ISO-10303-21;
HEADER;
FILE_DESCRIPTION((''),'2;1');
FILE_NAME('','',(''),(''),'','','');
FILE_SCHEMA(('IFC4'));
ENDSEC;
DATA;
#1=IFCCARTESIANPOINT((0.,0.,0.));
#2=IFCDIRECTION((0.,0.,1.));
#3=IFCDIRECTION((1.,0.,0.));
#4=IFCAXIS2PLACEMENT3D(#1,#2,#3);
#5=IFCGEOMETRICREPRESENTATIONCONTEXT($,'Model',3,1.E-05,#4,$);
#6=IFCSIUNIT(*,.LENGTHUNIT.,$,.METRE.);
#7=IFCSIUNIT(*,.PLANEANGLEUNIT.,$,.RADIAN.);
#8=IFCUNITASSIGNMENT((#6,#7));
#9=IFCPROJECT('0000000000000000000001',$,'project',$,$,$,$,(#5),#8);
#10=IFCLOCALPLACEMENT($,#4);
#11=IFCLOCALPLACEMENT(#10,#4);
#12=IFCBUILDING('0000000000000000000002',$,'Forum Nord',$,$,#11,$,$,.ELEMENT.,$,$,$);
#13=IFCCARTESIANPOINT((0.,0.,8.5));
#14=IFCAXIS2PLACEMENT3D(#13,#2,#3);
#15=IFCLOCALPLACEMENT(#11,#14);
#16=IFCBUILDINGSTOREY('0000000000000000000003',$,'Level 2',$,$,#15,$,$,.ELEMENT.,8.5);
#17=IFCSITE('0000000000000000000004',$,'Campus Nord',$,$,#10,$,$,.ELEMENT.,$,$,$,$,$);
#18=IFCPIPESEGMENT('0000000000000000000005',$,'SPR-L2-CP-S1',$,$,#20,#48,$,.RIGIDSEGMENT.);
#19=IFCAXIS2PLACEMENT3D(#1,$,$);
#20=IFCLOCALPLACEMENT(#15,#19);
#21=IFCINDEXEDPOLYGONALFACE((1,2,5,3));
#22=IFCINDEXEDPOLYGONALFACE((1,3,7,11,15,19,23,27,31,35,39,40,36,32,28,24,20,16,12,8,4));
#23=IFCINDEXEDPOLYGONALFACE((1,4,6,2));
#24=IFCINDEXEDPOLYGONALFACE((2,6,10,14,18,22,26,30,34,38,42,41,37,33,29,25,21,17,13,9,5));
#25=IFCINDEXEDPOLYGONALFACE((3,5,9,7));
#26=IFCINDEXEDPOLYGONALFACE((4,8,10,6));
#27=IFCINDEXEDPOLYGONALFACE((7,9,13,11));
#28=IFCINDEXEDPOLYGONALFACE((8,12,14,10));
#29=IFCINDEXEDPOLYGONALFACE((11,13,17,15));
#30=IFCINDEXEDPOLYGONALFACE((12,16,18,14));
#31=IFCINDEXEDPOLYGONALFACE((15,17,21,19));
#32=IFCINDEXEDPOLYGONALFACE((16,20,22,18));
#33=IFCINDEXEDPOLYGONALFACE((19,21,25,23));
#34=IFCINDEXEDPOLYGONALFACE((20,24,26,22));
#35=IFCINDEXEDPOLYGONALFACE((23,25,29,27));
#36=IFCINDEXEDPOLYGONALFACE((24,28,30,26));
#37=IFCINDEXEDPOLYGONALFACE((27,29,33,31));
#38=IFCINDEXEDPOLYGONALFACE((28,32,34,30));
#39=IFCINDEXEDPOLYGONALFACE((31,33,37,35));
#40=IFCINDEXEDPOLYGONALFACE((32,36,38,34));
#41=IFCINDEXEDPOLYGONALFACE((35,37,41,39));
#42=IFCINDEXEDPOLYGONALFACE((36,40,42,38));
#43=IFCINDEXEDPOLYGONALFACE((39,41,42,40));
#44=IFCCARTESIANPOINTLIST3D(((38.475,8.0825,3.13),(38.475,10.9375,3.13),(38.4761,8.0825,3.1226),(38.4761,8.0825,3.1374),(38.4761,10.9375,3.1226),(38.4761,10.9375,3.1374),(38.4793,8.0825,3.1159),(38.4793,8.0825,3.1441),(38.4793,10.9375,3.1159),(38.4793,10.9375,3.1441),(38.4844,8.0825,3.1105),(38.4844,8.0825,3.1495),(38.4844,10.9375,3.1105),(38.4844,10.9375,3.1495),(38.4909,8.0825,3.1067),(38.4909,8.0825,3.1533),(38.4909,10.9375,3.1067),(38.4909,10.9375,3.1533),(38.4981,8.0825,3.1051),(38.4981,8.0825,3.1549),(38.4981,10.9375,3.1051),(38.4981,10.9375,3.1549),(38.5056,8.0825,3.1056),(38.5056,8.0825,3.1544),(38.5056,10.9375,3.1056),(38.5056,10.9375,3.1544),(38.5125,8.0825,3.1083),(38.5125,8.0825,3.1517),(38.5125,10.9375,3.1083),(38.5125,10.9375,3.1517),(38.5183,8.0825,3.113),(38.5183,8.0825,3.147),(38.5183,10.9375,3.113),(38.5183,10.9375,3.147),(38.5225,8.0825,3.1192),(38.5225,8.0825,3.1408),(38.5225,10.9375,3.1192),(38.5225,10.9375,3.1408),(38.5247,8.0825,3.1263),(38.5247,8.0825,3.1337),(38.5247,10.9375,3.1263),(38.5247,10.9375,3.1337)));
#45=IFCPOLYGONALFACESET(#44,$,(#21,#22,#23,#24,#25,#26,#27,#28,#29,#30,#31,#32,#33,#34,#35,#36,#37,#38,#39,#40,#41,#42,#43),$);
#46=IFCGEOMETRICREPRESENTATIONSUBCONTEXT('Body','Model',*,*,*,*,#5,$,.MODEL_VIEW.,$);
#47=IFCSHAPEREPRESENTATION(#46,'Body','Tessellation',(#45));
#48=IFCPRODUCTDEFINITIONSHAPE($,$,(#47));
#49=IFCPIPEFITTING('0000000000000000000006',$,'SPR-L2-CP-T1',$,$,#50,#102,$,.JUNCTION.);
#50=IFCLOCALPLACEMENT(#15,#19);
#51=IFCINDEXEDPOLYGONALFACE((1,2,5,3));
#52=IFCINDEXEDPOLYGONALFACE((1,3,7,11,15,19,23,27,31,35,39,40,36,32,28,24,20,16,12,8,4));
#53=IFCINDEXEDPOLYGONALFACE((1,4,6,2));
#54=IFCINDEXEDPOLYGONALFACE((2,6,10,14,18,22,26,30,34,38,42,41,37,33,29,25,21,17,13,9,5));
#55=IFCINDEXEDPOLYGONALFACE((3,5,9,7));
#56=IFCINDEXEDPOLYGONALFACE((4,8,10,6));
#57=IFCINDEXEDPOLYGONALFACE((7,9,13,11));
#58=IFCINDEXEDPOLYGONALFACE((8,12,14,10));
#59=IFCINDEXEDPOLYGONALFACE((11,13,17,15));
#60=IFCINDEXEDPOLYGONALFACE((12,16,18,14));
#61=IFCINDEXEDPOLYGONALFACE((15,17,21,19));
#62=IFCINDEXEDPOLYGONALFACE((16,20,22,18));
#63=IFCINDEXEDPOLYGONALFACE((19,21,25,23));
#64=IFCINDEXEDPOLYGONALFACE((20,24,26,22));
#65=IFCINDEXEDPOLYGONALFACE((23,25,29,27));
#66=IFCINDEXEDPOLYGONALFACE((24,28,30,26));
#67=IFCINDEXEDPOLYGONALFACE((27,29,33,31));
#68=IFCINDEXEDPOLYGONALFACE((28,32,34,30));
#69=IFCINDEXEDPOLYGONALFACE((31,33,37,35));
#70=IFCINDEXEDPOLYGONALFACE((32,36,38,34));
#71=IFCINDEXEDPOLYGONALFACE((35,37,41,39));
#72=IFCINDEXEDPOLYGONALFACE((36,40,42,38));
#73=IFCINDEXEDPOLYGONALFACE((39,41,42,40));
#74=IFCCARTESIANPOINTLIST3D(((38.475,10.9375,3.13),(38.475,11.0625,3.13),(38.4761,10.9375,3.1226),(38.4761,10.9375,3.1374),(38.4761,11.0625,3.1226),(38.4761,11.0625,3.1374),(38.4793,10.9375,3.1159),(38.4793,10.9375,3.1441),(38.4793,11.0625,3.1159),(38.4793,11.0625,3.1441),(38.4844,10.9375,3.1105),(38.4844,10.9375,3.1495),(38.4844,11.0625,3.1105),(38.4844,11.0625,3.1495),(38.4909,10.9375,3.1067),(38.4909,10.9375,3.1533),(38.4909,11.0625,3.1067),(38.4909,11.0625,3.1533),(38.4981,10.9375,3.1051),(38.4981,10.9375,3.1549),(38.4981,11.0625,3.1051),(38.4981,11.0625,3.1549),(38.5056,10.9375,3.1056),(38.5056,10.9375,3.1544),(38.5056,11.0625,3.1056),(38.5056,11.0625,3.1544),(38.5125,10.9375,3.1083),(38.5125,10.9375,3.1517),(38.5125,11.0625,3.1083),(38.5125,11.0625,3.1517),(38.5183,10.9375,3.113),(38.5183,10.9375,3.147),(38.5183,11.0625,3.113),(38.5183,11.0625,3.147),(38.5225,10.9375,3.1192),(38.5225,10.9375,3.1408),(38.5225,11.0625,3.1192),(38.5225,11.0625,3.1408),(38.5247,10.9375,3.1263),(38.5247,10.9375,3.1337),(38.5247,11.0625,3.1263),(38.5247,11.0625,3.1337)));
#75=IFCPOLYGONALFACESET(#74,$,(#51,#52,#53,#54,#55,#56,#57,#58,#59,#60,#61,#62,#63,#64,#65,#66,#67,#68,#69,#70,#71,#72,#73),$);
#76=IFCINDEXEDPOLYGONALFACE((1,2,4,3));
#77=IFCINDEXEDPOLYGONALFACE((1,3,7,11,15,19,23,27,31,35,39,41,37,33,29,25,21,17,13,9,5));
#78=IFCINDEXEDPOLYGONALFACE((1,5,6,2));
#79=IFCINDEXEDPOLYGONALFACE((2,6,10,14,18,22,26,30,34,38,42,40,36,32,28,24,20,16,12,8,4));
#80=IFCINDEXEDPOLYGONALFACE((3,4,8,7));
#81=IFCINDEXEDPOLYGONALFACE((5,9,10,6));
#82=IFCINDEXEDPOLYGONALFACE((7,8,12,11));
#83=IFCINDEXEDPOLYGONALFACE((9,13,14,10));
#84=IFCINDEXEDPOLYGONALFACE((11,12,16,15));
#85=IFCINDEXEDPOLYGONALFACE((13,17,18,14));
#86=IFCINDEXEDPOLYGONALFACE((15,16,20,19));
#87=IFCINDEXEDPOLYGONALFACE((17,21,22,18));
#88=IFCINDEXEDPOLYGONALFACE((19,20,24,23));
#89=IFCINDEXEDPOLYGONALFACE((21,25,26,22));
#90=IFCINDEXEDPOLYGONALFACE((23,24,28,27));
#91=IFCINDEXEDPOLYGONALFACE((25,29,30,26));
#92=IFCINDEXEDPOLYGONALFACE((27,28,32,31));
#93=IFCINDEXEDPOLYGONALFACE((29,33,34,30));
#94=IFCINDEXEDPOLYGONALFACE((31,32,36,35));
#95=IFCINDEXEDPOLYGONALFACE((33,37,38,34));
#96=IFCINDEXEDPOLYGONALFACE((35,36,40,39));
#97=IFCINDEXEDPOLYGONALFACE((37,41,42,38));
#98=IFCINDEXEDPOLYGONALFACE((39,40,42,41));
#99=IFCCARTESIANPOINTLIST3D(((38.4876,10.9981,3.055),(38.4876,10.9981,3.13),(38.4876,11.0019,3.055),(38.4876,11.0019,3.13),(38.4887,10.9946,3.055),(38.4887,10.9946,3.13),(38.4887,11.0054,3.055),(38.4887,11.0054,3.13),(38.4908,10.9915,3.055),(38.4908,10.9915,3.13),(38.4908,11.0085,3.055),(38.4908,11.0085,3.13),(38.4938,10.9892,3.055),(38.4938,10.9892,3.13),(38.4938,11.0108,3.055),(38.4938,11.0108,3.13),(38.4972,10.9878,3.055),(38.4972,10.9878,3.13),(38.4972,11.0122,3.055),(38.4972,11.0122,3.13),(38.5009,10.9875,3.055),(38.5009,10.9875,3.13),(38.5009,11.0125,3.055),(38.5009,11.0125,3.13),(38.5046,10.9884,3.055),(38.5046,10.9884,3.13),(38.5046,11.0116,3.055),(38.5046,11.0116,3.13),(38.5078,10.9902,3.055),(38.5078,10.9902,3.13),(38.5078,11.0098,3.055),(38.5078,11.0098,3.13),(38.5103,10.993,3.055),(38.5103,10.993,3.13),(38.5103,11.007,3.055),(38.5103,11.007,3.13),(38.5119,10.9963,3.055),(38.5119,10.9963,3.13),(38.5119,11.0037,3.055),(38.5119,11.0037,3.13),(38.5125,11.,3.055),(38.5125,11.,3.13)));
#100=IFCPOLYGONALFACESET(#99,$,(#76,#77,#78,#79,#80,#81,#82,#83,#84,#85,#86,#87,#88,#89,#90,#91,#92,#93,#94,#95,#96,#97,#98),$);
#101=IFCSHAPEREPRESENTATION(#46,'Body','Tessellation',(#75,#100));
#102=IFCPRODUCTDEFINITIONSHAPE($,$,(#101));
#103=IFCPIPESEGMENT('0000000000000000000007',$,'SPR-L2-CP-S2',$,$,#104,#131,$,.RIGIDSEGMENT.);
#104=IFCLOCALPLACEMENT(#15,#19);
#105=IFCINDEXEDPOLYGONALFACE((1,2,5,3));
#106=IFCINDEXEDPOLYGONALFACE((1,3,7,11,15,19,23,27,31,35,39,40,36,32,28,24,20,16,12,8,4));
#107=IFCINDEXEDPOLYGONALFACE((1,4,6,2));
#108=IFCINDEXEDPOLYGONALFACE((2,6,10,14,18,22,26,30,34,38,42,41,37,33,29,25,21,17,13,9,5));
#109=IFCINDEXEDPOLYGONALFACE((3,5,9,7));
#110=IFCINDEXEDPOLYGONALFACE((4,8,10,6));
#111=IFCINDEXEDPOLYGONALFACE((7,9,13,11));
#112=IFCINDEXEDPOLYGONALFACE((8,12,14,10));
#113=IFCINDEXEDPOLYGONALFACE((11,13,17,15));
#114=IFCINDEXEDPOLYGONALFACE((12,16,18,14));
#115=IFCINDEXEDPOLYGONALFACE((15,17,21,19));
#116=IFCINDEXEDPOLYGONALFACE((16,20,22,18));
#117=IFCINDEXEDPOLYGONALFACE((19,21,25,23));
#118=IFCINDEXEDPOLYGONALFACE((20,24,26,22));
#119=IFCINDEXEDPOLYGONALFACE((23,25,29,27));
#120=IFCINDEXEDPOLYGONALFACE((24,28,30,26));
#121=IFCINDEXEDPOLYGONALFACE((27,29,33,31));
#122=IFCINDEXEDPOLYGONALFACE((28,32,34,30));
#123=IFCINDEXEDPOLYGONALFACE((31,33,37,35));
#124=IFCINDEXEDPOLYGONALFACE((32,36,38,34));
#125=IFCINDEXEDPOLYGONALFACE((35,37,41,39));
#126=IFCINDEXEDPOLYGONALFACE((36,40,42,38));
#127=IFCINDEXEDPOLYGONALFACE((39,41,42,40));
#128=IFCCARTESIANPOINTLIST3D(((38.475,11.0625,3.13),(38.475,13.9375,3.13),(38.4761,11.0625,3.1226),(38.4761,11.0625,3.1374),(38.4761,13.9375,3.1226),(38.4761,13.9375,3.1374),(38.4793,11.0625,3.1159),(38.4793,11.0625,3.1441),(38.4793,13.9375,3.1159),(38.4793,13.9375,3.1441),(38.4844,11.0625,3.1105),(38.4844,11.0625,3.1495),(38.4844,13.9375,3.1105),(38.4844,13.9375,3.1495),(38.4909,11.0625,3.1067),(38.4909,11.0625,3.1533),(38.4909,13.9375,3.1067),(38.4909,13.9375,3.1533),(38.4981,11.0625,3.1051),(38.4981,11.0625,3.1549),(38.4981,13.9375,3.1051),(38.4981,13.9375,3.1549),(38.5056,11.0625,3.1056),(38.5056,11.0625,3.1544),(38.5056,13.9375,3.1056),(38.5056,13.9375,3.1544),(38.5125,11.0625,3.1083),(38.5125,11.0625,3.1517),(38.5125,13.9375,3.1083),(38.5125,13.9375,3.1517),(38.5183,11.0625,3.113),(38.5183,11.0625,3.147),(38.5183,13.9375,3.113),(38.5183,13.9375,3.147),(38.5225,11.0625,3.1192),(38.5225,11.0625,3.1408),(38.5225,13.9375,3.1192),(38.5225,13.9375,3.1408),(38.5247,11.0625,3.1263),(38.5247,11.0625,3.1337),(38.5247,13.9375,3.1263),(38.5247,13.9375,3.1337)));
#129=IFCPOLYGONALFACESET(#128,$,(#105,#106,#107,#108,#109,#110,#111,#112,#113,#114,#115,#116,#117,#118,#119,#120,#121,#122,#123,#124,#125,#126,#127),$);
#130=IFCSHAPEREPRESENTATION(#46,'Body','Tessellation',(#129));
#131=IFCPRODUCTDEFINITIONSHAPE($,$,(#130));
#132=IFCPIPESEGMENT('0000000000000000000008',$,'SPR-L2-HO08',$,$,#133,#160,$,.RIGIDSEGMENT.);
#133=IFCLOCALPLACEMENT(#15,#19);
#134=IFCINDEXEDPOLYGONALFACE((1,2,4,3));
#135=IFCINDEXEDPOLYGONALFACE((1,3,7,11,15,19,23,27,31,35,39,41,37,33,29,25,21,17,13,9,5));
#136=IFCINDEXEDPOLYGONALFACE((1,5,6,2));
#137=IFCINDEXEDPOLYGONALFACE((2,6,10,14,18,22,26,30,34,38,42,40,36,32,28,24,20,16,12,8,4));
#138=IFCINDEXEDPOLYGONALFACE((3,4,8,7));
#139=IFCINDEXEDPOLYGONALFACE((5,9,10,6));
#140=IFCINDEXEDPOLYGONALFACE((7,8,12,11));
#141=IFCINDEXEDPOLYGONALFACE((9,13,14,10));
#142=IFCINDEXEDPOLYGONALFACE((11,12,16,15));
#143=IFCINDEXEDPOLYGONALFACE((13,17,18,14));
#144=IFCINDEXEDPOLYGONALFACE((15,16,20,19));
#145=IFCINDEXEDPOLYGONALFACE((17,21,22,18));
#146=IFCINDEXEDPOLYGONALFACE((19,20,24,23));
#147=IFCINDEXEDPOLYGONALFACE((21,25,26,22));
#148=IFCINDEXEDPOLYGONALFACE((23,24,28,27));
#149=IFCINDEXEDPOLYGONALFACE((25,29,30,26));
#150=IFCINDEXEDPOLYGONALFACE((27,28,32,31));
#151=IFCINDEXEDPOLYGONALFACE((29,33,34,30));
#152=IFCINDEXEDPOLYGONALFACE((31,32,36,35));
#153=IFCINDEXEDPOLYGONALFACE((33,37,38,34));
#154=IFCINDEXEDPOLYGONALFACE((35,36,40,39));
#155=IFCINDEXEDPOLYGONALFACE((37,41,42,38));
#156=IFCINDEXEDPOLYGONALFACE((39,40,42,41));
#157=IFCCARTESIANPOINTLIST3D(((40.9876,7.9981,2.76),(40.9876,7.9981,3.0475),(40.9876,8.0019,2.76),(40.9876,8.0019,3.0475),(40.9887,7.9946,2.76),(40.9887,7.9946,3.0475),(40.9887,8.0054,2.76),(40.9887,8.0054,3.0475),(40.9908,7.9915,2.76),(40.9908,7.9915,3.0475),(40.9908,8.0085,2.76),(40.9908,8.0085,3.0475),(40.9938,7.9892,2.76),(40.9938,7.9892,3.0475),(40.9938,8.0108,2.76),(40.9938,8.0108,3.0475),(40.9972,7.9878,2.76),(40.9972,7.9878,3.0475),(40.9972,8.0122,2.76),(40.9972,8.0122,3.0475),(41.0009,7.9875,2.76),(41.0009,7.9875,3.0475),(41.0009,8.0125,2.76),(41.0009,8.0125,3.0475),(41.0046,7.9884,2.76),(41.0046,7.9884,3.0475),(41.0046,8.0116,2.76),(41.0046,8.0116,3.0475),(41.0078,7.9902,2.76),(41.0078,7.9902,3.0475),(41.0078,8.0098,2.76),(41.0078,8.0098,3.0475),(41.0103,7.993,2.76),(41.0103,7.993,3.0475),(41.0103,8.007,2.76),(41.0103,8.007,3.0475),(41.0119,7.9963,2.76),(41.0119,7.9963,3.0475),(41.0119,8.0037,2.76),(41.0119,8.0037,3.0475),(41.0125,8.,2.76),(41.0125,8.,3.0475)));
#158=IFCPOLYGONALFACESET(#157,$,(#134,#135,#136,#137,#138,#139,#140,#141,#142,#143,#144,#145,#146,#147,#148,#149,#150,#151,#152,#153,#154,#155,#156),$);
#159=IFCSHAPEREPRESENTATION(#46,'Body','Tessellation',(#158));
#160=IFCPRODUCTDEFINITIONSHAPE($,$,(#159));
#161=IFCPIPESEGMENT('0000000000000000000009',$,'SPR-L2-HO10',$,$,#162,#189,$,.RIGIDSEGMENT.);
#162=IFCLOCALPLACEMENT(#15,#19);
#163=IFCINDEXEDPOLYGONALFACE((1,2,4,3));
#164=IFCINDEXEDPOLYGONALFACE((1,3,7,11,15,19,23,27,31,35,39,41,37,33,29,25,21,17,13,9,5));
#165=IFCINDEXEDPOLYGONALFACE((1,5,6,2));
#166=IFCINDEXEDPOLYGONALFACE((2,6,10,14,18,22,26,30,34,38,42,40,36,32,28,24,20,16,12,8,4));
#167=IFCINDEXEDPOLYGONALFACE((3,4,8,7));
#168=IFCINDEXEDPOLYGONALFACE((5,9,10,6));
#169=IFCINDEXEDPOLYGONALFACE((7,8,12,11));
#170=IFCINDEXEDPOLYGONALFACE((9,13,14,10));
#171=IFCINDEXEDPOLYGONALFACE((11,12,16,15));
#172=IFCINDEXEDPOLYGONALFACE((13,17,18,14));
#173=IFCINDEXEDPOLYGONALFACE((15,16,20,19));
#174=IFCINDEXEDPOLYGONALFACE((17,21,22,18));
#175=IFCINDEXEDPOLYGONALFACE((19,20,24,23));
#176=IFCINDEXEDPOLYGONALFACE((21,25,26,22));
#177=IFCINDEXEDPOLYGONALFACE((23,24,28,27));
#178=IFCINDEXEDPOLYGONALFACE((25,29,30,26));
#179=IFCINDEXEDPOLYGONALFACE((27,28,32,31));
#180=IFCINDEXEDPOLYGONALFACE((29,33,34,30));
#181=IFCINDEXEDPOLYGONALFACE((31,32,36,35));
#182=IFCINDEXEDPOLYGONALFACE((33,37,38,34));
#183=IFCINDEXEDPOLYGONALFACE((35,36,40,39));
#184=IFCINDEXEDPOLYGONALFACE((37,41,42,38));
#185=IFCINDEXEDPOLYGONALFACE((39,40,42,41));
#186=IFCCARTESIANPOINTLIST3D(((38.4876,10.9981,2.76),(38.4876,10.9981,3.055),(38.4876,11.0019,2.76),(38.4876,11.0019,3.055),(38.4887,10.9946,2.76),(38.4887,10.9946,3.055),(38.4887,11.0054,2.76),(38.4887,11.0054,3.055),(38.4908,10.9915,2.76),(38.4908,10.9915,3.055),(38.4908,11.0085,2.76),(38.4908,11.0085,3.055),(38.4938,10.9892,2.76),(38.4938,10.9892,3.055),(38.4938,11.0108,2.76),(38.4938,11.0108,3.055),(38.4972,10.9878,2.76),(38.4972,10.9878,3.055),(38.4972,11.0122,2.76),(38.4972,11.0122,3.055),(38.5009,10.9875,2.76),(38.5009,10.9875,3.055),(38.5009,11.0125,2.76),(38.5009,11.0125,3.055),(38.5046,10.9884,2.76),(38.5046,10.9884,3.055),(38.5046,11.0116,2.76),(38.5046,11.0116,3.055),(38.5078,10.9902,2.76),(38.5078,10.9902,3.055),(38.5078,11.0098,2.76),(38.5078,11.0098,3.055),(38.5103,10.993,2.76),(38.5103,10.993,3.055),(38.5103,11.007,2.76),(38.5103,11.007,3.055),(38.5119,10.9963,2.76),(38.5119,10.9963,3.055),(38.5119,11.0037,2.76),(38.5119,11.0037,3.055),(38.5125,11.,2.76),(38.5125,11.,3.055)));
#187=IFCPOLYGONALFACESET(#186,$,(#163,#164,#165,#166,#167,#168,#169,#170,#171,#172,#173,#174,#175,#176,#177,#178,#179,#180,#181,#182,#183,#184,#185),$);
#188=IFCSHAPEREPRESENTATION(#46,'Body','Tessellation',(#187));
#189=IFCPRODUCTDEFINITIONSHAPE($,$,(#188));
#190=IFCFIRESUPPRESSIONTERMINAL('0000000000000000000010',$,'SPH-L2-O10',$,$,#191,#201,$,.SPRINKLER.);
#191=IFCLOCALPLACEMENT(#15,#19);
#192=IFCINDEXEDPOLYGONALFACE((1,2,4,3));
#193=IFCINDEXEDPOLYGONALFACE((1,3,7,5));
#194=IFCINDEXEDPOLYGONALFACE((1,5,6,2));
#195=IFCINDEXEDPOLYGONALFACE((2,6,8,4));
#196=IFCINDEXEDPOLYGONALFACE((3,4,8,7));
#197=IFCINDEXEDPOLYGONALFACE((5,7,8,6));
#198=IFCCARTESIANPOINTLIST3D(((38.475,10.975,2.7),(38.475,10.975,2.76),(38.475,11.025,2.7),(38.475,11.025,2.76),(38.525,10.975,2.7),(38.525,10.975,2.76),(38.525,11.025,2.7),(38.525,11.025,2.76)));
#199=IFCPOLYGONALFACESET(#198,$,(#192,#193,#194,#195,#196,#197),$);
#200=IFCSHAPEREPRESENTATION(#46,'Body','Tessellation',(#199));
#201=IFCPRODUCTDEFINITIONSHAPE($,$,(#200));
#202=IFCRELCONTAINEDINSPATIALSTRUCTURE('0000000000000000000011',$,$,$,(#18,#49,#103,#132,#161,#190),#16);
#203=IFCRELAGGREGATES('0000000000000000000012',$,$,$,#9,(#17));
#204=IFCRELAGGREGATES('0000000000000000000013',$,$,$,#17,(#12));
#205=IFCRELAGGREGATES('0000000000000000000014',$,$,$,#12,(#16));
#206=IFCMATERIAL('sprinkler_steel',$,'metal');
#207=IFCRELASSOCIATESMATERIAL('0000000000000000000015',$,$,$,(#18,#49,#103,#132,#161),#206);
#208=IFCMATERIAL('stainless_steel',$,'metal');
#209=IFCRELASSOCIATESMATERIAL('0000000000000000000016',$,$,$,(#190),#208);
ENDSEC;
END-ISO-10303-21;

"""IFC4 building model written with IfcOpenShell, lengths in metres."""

from ifc_helpers import new_model, si_unit, frame, origin_with_axes, origin_2d_with_axis, place, context, subcontext, project, spatial, rectangle, circle, extrude, material, element, save


model = new_model("IFC4")

# Units and contexts
model_context = context("Model", 3, precision=1e-05, world=origin_with_axes())
body_context = subcontext(model_context, "Body", "Model", "MODEL_VIEW")
ifc_project = project(units=[si_unit("LENGTHUNIT", "METRE"), si_unit("PLANEANGLEUNIT", "RADIAN")], contexts=[model_context])

# Site, building, storey
site_placement = place(None, origin_with_axes())
site = spatial("IfcSite", under=ifc_project, at=site_placement, Name="Campus Nord", CompositionType="ELEMENT")
building_placement = place(site_placement, origin_with_axes())
building = spatial("IfcBuilding", under=site, at=building_placement, Name="Forum Nord", CompositionType="ELEMENT")
storey_placement = place(building_placement, frame((0.0, 0.0, 8.5), z_axis=(0.0, 0.0, 1.0), x_axis=(1.0, 0.0, 0.0)))
storey = spatial("IfcBuildingStorey", under=building, at=storey_placement, Name="Level 2", CompositionType="ELEMENT", Elevation=8.5)

# Shared definitions
ifc_material_1 = material(Name="sprinkler_steel", Category="metal")

# Pipe segment
pipe_segment_1_placement = place(storey_placement, frame((38.5, 8.0825, 3.13), z_axis=(0.0, 1.0, 0.0), x_axis=(-1.0, 0.0, 0.0)))
element("IfcPipeSegment", 1, at=pipe_segment_1_placement, inside=storey, material=ifc_material_1, Name="SPR-L2-CP-S1", PredefinedType="RIGIDSEGMENT", context=body_context, shape_type="SweptSolid", body=[
    extrude(circle(Radius=0.025, at=origin_2d_with_axis()), origin_with_axes(), (0.0, 0.0, 1.0), 2.855),
])

# Pipe fitting
pipe_fitting_1_placement = place(storey_placement, frame((38.5, 10.9375, 3.13), z_axis=(0.0, 1.0, 0.0), x_axis=(-1.0, 0.0, 0.0)))
element("IfcPipeFitting", 2, at=pipe_fitting_1_placement, inside=storey, material=ifc_material_1, Name="SPR-L2-CP-T1", PredefinedType="JUNCTION", context=body_context, shape_type="SweptSolid", body=[
    extrude(circle(Radius=0.025, at=origin_2d_with_axis()), origin_with_axes(), (0.0, 0.0, 1.0), 0.125),
    extrude(circle(Radius=0.0125, at=origin_2d_with_axis()), frame((0.0, 0.0, 0.0625), z_axis=(0.0, -1.0, 0.0), x_axis=(-1.0, 0.0, 0.0)), (0.0, 0.0, 1.0), 0.075),
])

# Pipe segments
pipe_segment_2_placement = place(storey_placement, frame((38.5, 11.0625, 3.13), z_axis=(0.0, 1.0, 0.0), x_axis=(-1.0, 0.0, 0.0)))
element("IfcPipeSegment", 3, at=pipe_segment_2_placement, inside=storey, material=ifc_material_1, Name="SPR-L2-CP-S2", PredefinedType="RIGIDSEGMENT", context=body_context, shape_type="SweptSolid", body=[
    extrude(circle(Radius=0.025, at=origin_2d_with_axis()), origin_with_axes(), (0.0, 0.0, 1.0), 2.875),
])
pipe_segment_3_placement = place(storey_placement, frame((41.0, 8.0, 3.0475), z_axis=(0.0, 0.0, -1.0), x_axis=(1.0, 0.0, 0.0)))
element("IfcPipeSegment", 4, at=pipe_segment_3_placement, inside=storey, material=ifc_material_1, Name="SPR-L2-HO08", PredefinedType="RIGIDSEGMENT", context=body_context, shape_type="SweptSolid", body=[
    extrude(circle(Radius=0.0125, at=origin_2d_with_axis()), origin_with_axes(), (0.0, 0.0, 1.0), 0.2875),
])
pipe_segment_4_placement = place(storey_placement, frame((38.5, 11.0, 3.055), z_axis=(0.0, 0.0, -1.0), x_axis=(1.0, 0.0, 0.0)))
element("IfcPipeSegment", 5, at=pipe_segment_4_placement, inside=storey, material=ifc_material_1, Name="SPR-L2-HO10", PredefinedType="RIGIDSEGMENT", context=body_context, shape_type="SweptSolid", body=[
    extrude(circle(Radius=0.0125, at=origin_2d_with_axis()), origin_with_axes(), (0.0, 0.0, 1.0), 0.295),
])

# Fire suppression terminal
ifc_material_2 = material(Name="stainless_steel", Category="metal")
fire_suppression_terminal_placement = place(storey_placement, frame((38.5, 11.0, 2.7), z_axis=(0.0, 0.0, 1.0), x_axis=(1.0, 0.0, 0.0)))
element("IfcFireSuppressionTerminal", 6, at=fire_suppression_terminal_placement, inside=storey, material=ifc_material_2, Name="SPH-L2-O10", PredefinedType="SPRINKLER", context=body_context, shape_type="SweptSolid", body=[
    extrude(rectangle(XDim=0.05, YDim=0.05, at=origin_2d_with_axis()), origin_with_axes(), (0.0, 0.0, 1.0), 0.06),
])

save(model, "model.ifc")
